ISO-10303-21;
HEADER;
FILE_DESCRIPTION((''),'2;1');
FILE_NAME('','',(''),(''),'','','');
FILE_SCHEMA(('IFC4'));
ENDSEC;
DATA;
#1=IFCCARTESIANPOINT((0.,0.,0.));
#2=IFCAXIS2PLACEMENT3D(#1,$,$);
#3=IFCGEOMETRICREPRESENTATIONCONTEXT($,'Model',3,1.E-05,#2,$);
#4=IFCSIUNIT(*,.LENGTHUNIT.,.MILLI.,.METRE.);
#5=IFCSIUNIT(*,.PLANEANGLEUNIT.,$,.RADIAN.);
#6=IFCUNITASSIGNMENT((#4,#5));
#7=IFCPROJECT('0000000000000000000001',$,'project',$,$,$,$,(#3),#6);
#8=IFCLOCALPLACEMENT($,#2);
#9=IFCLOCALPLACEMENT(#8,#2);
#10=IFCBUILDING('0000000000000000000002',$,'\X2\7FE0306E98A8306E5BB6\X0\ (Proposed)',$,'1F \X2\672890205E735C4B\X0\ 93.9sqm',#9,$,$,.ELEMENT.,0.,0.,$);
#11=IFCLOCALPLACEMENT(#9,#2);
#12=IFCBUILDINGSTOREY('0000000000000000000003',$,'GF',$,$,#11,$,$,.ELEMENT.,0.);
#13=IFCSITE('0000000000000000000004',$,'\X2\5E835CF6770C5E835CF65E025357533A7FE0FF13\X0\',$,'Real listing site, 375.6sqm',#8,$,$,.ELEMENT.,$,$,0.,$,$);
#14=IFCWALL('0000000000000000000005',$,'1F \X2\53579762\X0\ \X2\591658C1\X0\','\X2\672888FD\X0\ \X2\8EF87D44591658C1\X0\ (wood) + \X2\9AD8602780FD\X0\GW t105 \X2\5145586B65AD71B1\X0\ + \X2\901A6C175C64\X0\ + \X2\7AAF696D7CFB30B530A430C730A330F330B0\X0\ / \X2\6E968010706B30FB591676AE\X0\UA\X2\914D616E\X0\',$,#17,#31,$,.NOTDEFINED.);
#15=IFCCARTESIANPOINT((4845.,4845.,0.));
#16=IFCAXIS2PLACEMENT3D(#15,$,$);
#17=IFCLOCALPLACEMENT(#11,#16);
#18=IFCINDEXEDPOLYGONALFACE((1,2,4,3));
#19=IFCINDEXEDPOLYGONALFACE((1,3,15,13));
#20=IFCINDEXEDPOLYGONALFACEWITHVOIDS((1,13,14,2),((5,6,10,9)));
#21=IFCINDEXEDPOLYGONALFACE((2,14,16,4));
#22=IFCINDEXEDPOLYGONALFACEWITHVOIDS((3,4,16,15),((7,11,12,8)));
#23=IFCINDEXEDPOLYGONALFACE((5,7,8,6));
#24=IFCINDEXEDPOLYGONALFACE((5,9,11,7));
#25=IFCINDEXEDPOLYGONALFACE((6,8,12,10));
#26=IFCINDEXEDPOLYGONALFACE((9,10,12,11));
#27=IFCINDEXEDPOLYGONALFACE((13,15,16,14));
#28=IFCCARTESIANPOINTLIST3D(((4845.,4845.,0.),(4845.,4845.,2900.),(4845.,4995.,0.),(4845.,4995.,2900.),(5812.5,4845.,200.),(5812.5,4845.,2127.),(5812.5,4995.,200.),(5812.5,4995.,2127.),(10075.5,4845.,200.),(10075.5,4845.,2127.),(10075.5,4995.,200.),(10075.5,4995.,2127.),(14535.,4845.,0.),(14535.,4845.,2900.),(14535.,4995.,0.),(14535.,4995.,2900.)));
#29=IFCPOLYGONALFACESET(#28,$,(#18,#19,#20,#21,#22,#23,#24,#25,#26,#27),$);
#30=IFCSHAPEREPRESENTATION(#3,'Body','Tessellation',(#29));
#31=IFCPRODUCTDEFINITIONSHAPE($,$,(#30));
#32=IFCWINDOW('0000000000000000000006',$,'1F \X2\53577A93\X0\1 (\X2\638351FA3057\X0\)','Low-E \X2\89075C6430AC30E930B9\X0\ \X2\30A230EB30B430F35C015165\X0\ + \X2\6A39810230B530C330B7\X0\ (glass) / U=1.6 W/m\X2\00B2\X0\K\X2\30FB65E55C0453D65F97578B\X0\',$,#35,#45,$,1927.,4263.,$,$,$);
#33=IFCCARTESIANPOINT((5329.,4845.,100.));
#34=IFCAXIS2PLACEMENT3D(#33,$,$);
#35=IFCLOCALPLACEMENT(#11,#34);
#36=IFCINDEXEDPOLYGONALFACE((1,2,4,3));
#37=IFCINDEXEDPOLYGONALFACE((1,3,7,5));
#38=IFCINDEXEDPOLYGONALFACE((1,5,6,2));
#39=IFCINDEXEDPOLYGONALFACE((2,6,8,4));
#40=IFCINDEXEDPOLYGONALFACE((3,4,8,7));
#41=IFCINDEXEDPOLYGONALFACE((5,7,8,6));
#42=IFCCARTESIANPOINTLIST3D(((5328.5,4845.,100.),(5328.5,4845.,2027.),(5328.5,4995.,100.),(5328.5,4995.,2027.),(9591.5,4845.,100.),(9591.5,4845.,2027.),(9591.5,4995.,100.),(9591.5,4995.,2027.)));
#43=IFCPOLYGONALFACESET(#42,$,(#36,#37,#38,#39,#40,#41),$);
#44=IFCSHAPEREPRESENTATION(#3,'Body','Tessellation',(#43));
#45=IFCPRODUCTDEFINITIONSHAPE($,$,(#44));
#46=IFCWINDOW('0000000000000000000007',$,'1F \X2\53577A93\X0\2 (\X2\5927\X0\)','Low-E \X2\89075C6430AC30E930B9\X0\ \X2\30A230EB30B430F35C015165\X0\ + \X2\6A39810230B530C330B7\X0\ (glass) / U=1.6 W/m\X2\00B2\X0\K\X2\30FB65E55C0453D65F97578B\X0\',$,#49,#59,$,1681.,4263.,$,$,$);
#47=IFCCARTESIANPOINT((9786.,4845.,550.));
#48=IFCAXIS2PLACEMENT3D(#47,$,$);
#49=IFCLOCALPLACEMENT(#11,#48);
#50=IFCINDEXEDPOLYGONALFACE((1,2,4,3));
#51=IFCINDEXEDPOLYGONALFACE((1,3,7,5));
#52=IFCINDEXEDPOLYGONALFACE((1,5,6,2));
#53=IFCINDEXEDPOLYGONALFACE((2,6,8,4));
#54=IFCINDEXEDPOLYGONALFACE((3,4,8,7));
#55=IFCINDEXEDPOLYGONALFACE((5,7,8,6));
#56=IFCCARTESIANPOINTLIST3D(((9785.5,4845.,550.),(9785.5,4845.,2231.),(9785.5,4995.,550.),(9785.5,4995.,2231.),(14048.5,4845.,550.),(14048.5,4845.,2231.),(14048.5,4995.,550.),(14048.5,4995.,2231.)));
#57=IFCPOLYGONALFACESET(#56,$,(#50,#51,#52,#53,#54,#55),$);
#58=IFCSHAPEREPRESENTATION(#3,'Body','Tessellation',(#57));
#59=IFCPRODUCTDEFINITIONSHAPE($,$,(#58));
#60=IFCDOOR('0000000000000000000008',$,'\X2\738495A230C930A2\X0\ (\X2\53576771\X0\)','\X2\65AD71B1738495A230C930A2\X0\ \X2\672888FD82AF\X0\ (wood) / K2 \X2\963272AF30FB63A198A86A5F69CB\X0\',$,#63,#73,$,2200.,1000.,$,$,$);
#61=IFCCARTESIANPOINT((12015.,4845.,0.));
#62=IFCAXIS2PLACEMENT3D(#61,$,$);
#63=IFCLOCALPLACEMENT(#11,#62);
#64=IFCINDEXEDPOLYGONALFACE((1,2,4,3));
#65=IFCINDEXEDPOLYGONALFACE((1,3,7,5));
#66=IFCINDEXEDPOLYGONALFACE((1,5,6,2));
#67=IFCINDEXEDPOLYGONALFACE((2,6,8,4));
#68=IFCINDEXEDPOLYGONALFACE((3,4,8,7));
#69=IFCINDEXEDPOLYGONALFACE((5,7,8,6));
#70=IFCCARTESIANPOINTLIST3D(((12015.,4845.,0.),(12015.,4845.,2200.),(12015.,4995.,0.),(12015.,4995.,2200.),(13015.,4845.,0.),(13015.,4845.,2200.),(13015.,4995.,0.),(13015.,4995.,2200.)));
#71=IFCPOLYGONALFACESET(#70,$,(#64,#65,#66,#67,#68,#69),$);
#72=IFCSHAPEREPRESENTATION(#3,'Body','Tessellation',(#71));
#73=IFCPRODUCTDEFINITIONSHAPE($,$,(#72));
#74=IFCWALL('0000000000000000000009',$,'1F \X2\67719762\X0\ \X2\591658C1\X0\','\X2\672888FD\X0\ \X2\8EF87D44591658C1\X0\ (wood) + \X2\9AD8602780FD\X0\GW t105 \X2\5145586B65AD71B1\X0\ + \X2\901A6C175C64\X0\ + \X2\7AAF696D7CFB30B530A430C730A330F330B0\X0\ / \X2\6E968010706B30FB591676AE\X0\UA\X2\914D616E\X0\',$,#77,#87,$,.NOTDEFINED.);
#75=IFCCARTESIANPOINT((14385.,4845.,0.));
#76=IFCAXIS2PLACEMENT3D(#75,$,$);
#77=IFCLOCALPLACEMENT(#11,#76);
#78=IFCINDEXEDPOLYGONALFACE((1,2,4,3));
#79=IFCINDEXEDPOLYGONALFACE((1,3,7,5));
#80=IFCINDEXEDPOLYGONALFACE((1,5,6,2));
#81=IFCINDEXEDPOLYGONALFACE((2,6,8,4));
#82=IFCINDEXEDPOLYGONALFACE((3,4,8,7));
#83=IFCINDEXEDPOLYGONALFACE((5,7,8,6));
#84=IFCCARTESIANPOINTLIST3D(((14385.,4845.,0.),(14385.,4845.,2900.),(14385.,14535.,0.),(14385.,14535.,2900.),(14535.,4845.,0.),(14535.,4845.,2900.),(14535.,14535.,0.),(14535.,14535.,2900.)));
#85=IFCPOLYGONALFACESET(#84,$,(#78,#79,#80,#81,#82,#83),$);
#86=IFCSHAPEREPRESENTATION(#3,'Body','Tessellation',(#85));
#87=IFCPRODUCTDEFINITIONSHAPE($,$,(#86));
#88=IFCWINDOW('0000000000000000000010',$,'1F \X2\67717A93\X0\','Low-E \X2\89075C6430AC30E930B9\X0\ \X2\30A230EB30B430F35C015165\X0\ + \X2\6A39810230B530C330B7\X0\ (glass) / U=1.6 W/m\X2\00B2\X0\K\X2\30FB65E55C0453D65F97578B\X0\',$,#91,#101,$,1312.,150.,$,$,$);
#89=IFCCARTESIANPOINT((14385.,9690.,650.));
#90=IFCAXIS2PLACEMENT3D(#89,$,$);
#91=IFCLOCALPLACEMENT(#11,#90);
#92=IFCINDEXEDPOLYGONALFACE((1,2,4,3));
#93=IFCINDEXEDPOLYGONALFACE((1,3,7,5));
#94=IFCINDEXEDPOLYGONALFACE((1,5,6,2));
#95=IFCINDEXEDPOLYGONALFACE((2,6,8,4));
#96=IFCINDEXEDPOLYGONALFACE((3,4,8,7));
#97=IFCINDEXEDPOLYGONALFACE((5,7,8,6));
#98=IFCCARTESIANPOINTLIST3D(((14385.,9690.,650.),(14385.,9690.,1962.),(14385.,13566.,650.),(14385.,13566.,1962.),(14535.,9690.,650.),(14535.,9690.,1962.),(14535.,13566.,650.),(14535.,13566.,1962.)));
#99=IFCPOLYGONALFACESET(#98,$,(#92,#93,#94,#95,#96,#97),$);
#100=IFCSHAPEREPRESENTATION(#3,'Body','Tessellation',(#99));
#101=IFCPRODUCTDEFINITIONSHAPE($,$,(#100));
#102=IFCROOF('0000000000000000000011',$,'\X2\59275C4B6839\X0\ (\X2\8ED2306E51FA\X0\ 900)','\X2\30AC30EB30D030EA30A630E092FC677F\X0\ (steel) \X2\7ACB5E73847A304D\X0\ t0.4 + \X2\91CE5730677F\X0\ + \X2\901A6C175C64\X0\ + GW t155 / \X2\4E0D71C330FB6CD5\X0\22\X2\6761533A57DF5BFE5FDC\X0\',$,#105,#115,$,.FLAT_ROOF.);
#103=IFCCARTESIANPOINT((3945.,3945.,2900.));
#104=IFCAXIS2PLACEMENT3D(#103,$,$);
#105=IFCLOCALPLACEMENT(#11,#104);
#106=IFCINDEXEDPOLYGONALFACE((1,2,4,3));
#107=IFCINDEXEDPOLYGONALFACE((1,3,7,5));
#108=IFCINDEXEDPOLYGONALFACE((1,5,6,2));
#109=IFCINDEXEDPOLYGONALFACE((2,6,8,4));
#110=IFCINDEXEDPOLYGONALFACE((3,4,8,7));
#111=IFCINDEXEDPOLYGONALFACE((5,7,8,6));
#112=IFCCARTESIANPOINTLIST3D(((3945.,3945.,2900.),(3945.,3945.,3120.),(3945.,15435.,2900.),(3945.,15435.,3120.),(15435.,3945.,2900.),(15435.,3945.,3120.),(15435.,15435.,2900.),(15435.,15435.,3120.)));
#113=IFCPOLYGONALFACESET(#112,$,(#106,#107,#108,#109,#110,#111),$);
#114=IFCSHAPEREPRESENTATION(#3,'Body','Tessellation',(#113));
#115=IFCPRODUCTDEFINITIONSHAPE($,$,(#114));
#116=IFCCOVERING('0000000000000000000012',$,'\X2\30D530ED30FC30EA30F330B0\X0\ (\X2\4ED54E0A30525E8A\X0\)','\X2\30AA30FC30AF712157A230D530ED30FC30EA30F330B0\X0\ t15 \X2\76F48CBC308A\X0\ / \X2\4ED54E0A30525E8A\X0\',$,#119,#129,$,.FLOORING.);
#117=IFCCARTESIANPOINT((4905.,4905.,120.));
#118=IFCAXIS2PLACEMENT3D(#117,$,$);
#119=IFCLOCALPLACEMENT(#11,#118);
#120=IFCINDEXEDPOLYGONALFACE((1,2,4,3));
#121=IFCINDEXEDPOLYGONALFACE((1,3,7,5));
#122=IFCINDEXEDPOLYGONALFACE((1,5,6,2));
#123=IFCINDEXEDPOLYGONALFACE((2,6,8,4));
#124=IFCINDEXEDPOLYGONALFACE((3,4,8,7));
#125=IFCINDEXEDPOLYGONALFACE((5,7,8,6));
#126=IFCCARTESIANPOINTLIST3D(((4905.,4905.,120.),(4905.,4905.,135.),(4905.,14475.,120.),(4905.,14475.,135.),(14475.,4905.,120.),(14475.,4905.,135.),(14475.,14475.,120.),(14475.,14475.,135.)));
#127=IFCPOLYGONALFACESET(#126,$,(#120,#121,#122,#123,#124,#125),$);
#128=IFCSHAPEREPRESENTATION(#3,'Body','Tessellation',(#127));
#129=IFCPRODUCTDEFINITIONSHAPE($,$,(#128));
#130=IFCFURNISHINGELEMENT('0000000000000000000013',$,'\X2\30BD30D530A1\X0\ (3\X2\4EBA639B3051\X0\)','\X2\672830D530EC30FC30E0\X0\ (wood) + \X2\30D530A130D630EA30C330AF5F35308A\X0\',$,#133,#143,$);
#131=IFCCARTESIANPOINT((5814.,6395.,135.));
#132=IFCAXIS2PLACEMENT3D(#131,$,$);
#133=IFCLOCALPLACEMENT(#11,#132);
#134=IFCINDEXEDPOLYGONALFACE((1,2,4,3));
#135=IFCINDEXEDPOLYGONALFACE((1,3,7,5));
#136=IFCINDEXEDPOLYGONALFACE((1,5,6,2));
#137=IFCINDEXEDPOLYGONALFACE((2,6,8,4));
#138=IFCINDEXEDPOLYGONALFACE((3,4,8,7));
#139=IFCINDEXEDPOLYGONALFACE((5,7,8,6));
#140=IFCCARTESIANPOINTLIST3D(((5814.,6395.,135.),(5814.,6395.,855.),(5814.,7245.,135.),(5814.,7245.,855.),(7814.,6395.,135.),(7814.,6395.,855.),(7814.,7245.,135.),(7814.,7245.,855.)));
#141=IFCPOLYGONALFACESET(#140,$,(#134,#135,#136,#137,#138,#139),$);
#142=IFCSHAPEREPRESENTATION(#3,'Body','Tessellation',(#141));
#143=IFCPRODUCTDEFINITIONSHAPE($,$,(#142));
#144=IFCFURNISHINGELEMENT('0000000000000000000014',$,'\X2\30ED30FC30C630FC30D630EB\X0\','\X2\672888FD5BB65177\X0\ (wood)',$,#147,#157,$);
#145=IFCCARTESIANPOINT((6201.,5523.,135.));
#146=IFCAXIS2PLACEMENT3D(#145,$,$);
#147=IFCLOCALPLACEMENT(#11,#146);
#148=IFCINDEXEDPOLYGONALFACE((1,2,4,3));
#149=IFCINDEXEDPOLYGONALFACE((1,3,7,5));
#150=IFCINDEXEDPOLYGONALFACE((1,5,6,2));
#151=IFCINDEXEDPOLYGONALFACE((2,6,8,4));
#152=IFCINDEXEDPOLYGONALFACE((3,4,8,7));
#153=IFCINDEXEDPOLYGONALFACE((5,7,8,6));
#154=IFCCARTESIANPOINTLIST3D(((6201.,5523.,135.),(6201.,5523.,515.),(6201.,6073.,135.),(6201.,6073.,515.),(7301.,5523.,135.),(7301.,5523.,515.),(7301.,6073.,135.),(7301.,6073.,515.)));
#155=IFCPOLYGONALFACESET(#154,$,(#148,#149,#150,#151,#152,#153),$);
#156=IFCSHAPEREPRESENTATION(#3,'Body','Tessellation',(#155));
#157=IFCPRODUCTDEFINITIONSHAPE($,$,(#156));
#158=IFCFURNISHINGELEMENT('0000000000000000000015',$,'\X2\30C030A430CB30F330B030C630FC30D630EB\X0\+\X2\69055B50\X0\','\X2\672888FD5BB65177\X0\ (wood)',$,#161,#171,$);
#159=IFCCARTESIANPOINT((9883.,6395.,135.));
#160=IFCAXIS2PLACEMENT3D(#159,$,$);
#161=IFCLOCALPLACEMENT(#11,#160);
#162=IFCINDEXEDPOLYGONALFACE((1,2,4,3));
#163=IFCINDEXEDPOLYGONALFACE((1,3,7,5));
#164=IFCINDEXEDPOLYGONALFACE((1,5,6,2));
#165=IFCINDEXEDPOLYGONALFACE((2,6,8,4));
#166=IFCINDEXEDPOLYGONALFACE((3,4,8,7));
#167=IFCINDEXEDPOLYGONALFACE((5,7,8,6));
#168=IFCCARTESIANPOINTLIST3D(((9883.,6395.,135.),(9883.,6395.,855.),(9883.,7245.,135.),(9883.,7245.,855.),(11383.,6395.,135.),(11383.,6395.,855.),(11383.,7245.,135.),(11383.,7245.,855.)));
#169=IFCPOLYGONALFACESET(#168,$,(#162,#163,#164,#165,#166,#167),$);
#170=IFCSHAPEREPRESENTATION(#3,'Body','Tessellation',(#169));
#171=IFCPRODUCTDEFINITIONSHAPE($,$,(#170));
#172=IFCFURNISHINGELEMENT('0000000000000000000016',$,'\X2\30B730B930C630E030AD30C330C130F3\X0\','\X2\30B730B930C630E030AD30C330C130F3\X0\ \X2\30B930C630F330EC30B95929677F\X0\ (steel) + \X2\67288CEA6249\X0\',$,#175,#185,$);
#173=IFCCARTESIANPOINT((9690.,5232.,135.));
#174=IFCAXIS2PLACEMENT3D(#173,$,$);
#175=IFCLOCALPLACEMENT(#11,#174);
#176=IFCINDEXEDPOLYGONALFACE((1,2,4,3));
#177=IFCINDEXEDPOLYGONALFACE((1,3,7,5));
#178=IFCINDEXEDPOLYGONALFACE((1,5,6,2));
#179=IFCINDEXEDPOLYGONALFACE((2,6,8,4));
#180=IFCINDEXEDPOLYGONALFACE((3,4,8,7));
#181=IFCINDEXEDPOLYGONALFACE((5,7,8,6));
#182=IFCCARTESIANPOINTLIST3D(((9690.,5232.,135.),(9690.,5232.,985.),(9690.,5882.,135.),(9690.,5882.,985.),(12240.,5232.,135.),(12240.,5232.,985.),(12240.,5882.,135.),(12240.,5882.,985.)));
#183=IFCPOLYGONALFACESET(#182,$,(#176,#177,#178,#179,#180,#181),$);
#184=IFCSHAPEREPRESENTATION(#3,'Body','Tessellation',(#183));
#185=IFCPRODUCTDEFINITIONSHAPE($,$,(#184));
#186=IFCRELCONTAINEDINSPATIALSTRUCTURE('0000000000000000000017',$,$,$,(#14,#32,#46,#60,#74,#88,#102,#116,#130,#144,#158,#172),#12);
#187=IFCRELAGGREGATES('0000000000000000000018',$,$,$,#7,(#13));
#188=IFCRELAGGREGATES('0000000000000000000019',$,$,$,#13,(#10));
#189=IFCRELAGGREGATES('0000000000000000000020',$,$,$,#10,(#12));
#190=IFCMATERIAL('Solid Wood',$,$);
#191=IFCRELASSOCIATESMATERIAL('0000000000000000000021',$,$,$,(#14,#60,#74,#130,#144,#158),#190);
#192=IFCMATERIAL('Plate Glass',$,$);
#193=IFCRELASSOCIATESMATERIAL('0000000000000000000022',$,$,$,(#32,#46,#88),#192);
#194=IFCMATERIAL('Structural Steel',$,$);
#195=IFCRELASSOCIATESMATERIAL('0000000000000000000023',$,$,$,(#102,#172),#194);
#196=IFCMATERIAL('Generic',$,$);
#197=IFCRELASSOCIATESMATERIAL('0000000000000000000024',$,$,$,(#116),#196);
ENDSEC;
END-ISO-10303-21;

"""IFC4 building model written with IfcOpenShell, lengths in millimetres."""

from ifc_helpers import new_model, si_unit, frame, frame_2d, origin, place, context, project, spatial, rectangle, extrude, material, element, fill, save


model = new_model("IFC4")

# Units and contexts
model_context = context("Model", 3, precision=1e-05, world=origin())
ifc_project = project(units=[si_unit("LENGTHUNIT", "METRE", prefix="MILLI"), si_unit("PLANEANGLEUNIT", "RADIAN")], contexts=[model_context])

# Site, building, storey
site_placement = place(None, origin())
site = spatial("IfcSite", under=ifc_project, at=site_placement, Name="広島県広島市南区翠３", ObjectType="Real listing site, 375.6sqm", CompositionType="ELEMENT", RefElevation=0.0)
building_placement = place(site_placement, origin())
building = spatial("IfcBuilding", under=site, at=building_placement, Name="翠の風の家 (Proposed)", ObjectType="1F 木造平屋 93.9sqm", CompositionType="ELEMENT", ElevationOfRefHeight=0.0, ElevationOfTerrain=0.0)
storey_placement = place(building_placement, origin())
storey = spatial("IfcBuildingStorey", under=building, at=storey_placement, Name="GF", CompositionType="ELEMENT", Elevation=0.0)

# Shared definitions
ifc_material_1 = material(Name="Solid Wood")

# Wall, openings, windows, door
wall_1_placement = place(storey_placement, frame((4845.0, 4845.0, 0.0)))
wall_1 = element("IfcWall", 1, at=wall_1_placement, inside=storey, material=ifc_material_1, Name="1F 南面 外壁", Description="木製 軸組外壁 (wood) + 高性能GW t105 充填断熱 + 通気層 + 窯業系サイディング / 準耐火・外皮UA配慮", PredefinedType="NOTDEFINED", context=model_context, shape_type="SweptSolid", body=[
    extrude(rectangle(XDim=9690.0, YDim=150.0, at=frame_2d((4845.0, 75.0))), frame((4845.0, 4845.0, 0.0)), (0.0, 0.0, 1.0), 2900.0),
])
opening_1_placement = place(storey_placement, frame((5329.0, 4845.0, 100.0)))
opening_1 = element("IfcOpeningElement", 2, at=opening_1_placement, cuts=wall_1, PredefinedType="NOTDEFINED", context=model_context, shape_type="SweptSolid", body=[
    extrude(rectangle(XDim=4263.0, YDim=150.0, at=frame_2d((2131.0, 75.0))), frame((5329.0, 4845.0, 100.0)), (0.0, 0.0, 1.0), 1927.0),
])
opening_2_placement = place(storey_placement, frame((9786.0, 4845.0, 550.0)))
opening_2 = element("IfcOpeningElement", 3, at=opening_2_placement, cuts=wall_1, PredefinedType="NOTDEFINED", context=model_context, shape_type="SweptSolid", body=[
    extrude(rectangle(XDim=4263.0, YDim=150.0, at=frame_2d((2131.0, 75.0))), frame((9786.0, 4845.0, 550.0)), (0.0, 0.0, 1.0), 1681.0),
])
opening_3_placement = place(storey_placement, frame((12015.0, 4845.0, 0.0)))
opening_3 = element("IfcOpeningElement", 4, at=opening_3_placement, cuts=wall_1, PredefinedType="NOTDEFINED", context=model_context, shape_type="SweptSolid", body=[
    extrude(rectangle(XDim=1000.0, YDim=150.0, at=frame_2d((500.0, 75.0))), frame((12015.0, 4845.0, 0.0)), (0.0, 0.0, 1.0), 2200.0),
])
ifc_material_2 = material(Name="Plate Glass")
window_1_placement = place(storey_placement, frame((5329.0, 4845.0, 100.0)))
window_1 = element("IfcWindow", 5, at=window_1_placement, inside=storey, material=ifc_material_2, Name="1F 南窓1 (掃出し)", Description="Low-E 複層ガラス アルゴン封入 + 樹脂サッシ (glass) / U=1.6 W/m²K・日射取得型", OverallHeight=1927.0, OverallWidth=4263.0, context=model_context, shape_type="SweptSolid", body=[
    extrude(rectangle(XDim=4263.0, YDim=150.0, at=frame_2d((2131.0, 75.0))), frame((5329.0, 4845.0, 100.0)), (0.0, 0.0, 1.0), 1927.0),
])
fill(opening_1, window_1)
window_2_placement = place(storey_placement, frame((9786.0, 4845.0, 550.0)))
window_2 = element("IfcWindow", 6, at=window_2_placement, inside=storey, material=ifc_material_2, Name="1F 南窓2 (大)", Description="Low-E 複層ガラス アルゴン封入 + 樹脂サッシ (glass) / U=1.6 W/m²K・日射取得型", OverallHeight=1681.0, OverallWidth=4263.0, context=model_context, shape_type="SweptSolid", body=[
    extrude(rectangle(XDim=4263.0, YDim=150.0, at=frame_2d((2131.0, 75.0))), frame((9786.0, 4845.0, 550.0)), (0.0, 0.0, 1.0), 1681.0),
])
fill(opening_2, window_2)
door_placement = place(storey_placement, frame((12015.0, 4845.0, 0.0)))
door = element("IfcDoor", 7, at=door_placement, inside=storey, material=ifc_material_1, Name="玄関ドア (南東)", Description="断熱玄関ドア 木製芯 (wood) / K2 防犯・採風機構", OverallHeight=2200.0, OverallWidth=1000.0, context=model_context, shape_type="SweptSolid", body=[
    extrude(rectangle(XDim=1000.0, YDim=150.0, at=frame_2d((500.0, 75.0))), frame((12015.0, 4845.0, 0.0)), (0.0, 0.0, 1.0), 2200.0),
])
fill(opening_3, door)

# Wall, opening, window
wall_2_placement = place(storey_placement, frame((14385.0, 4845.0, 0.0)))
wall_2 = element("IfcWall", 8, at=wall_2_placement, inside=storey, material=ifc_material_1, Name="1F 東面 外壁", Description="木製 軸組外壁 (wood) + 高性能GW t105 充填断熱 + 通気層 + 窯業系サイディング / 準耐火・外皮UA配慮", PredefinedType="NOTDEFINED", context=model_context, shape_type="SweptSolid", body=[
    extrude(rectangle(XDim=150.0, YDim=9690.0, at=frame_2d((75.0, 4845.0))), frame((14385.0, 4845.0, 0.0)), (0.0, 0.0, 1.0), 2900.0),
])
opening_4_placement = place(storey_placement, frame((14385.0, 9690.0, 650.0)))
opening_4 = element("IfcOpeningElement", 9, at=opening_4_placement, cuts=wall_2, PredefinedType="NOTDEFINED", context=model_context, shape_type="SweptSolid", body=[
    extrude(rectangle(XDim=150.0, YDim=3876.0, at=frame_2d((75.0, 1938.0))), frame((14385.0, 9690.0, 650.0)), (0.0, 0.0, 1.0), 1312.0),
])
window_3_placement = place(storey_placement, frame((14385.0, 9690.0, 650.0)))
window_3 = element("IfcWindow", 10, at=window_3_placement, inside=storey, material=ifc_material_2, Name="1F 東窓", Description="Low-E 複層ガラス アルゴン封入 + 樹脂サッシ (glass) / U=1.6 W/m²K・日射取得型", OverallHeight=1312.0, OverallWidth=150.0, context=model_context, shape_type="SweptSolid", body=[
    extrude(rectangle(XDim=150.0, YDim=3876.0, at=frame_2d((75.0, 1938.0))), frame((14385.0, 9690.0, 650.0)), (0.0, 0.0, 1.0), 1312.0),
])
fill(opening_4, window_3)

# Roof
ifc_material_3 = material(Name="Structural Steel")
roof_placement = place(storey_placement, frame((3945.0, 3945.0, 2900.0)))
element("IfcRoof", 11, at=roof_placement, inside=storey, material=ifc_material_3, Name="大屋根 (軒の出 900)", Description="ガルバリウム鋼板 (steel) 立平葺き t0.4 + 野地板 + 通気層 + GW t155 / 不燃・法22条区域対応", PredefinedType="FLAT_ROOF", context=model_context, shape_type="SweptSolid", body=[
    extrude(rectangle(XDim=11490.0, YDim=11490.0, at=frame_2d((5745.0, 5745.0))), frame((3945.0, 3945.0, 2900.0)), (0.0, 0.0, 1.0), 220.0),
])

# Covering
ifc_material_4 = material(Name="Generic")
covering_placement = place(storey_placement, frame((4905.0, 4905.0, 120.0)))
element("IfcCovering", 12, at=covering_placement, inside=storey, material=ifc_material_4, Name="フローリング (仕上げ床)", Description="オーク無垢フローリング t15 直貼り / 仕上げ床", PredefinedType="FLOORING", context=model_context, shape_type="SweptSolid", body=[
    extrude(rectangle(XDim=9570.0, YDim=9570.0, at=frame_2d((4785.0, 4785.0))), frame((4905.0, 4905.0, 120.0)), (0.0, 0.0, 1.0), 15.0),
])

# Furnishing elements
furnishing_1_placement = place(storey_placement, frame((5814.0, 6395.0, 135.0)))
element("IfcFurnishingElement", 13, at=furnishing_1_placement, inside=storey, material=ifc_material_1, Name="ソファ (3人掛け)", Description="木フレーム (wood) + ファブリック張り", context=model_context, shape_type="SweptSolid", body=[
    extrude(rectangle(XDim=2000.0, YDim=850.0, at=frame_2d((1000.0, 425.0))), frame((5814.0, 6395.0, 135.0)), (0.0, 0.0, 1.0), 720.0),
])
furnishing_2_placement = place(storey_placement, frame((6201.0, 5523.0, 135.0)))
element("IfcFurnishingElement", 14, at=furnishing_2_placement, inside=storey, material=ifc_material_1, Name="ローテーブル", Description="木製家具 (wood)", context=model_context, shape_type="SweptSolid", body=[
    extrude(rectangle(XDim=1100.0, YDim=550.0, at=frame_2d((550.0, 275.0))), frame((6201.0, 5523.0, 135.0)), (0.0, 0.0, 1.0), 380.0),
])
furnishing_3_placement = place(storey_placement, frame((9883.0, 6395.0, 135.0)))
element("IfcFurnishingElement", 15, at=furnishing_3_placement, inside=storey, material=ifc_material_1, Name="ダイニングテーブル+椅子", Description="木製家具 (wood)", context=model_context, shape_type="SweptSolid", body=[
    extrude(rectangle(XDim=1500.0, YDim=850.0, at=frame_2d((750.0, 425.0))), frame((9883.0, 6395.0, 135.0)), (0.0, 0.0, 1.0), 720.0),
])
furnishing_4_placement = place(storey_placement, frame((9690.0, 5232.0, 135.0)))
element("IfcFurnishingElement", 16, at=furnishing_4_placement, inside=storey, material=ifc_material_3, Name="システムキッチン", Description="システムキッチン ステンレス天板 (steel) + 木質扉", context=model_context, shape_type="SweptSolid", body=[
    extrude(rectangle(XDim=2550.0, YDim=650.0, at=frame_2d((1275.0, 325.0))), frame((9690.0, 5232.0, 135.0)), (0.0, 0.0, 1.0), 850.0),
])

save(model, "model.ifc")
